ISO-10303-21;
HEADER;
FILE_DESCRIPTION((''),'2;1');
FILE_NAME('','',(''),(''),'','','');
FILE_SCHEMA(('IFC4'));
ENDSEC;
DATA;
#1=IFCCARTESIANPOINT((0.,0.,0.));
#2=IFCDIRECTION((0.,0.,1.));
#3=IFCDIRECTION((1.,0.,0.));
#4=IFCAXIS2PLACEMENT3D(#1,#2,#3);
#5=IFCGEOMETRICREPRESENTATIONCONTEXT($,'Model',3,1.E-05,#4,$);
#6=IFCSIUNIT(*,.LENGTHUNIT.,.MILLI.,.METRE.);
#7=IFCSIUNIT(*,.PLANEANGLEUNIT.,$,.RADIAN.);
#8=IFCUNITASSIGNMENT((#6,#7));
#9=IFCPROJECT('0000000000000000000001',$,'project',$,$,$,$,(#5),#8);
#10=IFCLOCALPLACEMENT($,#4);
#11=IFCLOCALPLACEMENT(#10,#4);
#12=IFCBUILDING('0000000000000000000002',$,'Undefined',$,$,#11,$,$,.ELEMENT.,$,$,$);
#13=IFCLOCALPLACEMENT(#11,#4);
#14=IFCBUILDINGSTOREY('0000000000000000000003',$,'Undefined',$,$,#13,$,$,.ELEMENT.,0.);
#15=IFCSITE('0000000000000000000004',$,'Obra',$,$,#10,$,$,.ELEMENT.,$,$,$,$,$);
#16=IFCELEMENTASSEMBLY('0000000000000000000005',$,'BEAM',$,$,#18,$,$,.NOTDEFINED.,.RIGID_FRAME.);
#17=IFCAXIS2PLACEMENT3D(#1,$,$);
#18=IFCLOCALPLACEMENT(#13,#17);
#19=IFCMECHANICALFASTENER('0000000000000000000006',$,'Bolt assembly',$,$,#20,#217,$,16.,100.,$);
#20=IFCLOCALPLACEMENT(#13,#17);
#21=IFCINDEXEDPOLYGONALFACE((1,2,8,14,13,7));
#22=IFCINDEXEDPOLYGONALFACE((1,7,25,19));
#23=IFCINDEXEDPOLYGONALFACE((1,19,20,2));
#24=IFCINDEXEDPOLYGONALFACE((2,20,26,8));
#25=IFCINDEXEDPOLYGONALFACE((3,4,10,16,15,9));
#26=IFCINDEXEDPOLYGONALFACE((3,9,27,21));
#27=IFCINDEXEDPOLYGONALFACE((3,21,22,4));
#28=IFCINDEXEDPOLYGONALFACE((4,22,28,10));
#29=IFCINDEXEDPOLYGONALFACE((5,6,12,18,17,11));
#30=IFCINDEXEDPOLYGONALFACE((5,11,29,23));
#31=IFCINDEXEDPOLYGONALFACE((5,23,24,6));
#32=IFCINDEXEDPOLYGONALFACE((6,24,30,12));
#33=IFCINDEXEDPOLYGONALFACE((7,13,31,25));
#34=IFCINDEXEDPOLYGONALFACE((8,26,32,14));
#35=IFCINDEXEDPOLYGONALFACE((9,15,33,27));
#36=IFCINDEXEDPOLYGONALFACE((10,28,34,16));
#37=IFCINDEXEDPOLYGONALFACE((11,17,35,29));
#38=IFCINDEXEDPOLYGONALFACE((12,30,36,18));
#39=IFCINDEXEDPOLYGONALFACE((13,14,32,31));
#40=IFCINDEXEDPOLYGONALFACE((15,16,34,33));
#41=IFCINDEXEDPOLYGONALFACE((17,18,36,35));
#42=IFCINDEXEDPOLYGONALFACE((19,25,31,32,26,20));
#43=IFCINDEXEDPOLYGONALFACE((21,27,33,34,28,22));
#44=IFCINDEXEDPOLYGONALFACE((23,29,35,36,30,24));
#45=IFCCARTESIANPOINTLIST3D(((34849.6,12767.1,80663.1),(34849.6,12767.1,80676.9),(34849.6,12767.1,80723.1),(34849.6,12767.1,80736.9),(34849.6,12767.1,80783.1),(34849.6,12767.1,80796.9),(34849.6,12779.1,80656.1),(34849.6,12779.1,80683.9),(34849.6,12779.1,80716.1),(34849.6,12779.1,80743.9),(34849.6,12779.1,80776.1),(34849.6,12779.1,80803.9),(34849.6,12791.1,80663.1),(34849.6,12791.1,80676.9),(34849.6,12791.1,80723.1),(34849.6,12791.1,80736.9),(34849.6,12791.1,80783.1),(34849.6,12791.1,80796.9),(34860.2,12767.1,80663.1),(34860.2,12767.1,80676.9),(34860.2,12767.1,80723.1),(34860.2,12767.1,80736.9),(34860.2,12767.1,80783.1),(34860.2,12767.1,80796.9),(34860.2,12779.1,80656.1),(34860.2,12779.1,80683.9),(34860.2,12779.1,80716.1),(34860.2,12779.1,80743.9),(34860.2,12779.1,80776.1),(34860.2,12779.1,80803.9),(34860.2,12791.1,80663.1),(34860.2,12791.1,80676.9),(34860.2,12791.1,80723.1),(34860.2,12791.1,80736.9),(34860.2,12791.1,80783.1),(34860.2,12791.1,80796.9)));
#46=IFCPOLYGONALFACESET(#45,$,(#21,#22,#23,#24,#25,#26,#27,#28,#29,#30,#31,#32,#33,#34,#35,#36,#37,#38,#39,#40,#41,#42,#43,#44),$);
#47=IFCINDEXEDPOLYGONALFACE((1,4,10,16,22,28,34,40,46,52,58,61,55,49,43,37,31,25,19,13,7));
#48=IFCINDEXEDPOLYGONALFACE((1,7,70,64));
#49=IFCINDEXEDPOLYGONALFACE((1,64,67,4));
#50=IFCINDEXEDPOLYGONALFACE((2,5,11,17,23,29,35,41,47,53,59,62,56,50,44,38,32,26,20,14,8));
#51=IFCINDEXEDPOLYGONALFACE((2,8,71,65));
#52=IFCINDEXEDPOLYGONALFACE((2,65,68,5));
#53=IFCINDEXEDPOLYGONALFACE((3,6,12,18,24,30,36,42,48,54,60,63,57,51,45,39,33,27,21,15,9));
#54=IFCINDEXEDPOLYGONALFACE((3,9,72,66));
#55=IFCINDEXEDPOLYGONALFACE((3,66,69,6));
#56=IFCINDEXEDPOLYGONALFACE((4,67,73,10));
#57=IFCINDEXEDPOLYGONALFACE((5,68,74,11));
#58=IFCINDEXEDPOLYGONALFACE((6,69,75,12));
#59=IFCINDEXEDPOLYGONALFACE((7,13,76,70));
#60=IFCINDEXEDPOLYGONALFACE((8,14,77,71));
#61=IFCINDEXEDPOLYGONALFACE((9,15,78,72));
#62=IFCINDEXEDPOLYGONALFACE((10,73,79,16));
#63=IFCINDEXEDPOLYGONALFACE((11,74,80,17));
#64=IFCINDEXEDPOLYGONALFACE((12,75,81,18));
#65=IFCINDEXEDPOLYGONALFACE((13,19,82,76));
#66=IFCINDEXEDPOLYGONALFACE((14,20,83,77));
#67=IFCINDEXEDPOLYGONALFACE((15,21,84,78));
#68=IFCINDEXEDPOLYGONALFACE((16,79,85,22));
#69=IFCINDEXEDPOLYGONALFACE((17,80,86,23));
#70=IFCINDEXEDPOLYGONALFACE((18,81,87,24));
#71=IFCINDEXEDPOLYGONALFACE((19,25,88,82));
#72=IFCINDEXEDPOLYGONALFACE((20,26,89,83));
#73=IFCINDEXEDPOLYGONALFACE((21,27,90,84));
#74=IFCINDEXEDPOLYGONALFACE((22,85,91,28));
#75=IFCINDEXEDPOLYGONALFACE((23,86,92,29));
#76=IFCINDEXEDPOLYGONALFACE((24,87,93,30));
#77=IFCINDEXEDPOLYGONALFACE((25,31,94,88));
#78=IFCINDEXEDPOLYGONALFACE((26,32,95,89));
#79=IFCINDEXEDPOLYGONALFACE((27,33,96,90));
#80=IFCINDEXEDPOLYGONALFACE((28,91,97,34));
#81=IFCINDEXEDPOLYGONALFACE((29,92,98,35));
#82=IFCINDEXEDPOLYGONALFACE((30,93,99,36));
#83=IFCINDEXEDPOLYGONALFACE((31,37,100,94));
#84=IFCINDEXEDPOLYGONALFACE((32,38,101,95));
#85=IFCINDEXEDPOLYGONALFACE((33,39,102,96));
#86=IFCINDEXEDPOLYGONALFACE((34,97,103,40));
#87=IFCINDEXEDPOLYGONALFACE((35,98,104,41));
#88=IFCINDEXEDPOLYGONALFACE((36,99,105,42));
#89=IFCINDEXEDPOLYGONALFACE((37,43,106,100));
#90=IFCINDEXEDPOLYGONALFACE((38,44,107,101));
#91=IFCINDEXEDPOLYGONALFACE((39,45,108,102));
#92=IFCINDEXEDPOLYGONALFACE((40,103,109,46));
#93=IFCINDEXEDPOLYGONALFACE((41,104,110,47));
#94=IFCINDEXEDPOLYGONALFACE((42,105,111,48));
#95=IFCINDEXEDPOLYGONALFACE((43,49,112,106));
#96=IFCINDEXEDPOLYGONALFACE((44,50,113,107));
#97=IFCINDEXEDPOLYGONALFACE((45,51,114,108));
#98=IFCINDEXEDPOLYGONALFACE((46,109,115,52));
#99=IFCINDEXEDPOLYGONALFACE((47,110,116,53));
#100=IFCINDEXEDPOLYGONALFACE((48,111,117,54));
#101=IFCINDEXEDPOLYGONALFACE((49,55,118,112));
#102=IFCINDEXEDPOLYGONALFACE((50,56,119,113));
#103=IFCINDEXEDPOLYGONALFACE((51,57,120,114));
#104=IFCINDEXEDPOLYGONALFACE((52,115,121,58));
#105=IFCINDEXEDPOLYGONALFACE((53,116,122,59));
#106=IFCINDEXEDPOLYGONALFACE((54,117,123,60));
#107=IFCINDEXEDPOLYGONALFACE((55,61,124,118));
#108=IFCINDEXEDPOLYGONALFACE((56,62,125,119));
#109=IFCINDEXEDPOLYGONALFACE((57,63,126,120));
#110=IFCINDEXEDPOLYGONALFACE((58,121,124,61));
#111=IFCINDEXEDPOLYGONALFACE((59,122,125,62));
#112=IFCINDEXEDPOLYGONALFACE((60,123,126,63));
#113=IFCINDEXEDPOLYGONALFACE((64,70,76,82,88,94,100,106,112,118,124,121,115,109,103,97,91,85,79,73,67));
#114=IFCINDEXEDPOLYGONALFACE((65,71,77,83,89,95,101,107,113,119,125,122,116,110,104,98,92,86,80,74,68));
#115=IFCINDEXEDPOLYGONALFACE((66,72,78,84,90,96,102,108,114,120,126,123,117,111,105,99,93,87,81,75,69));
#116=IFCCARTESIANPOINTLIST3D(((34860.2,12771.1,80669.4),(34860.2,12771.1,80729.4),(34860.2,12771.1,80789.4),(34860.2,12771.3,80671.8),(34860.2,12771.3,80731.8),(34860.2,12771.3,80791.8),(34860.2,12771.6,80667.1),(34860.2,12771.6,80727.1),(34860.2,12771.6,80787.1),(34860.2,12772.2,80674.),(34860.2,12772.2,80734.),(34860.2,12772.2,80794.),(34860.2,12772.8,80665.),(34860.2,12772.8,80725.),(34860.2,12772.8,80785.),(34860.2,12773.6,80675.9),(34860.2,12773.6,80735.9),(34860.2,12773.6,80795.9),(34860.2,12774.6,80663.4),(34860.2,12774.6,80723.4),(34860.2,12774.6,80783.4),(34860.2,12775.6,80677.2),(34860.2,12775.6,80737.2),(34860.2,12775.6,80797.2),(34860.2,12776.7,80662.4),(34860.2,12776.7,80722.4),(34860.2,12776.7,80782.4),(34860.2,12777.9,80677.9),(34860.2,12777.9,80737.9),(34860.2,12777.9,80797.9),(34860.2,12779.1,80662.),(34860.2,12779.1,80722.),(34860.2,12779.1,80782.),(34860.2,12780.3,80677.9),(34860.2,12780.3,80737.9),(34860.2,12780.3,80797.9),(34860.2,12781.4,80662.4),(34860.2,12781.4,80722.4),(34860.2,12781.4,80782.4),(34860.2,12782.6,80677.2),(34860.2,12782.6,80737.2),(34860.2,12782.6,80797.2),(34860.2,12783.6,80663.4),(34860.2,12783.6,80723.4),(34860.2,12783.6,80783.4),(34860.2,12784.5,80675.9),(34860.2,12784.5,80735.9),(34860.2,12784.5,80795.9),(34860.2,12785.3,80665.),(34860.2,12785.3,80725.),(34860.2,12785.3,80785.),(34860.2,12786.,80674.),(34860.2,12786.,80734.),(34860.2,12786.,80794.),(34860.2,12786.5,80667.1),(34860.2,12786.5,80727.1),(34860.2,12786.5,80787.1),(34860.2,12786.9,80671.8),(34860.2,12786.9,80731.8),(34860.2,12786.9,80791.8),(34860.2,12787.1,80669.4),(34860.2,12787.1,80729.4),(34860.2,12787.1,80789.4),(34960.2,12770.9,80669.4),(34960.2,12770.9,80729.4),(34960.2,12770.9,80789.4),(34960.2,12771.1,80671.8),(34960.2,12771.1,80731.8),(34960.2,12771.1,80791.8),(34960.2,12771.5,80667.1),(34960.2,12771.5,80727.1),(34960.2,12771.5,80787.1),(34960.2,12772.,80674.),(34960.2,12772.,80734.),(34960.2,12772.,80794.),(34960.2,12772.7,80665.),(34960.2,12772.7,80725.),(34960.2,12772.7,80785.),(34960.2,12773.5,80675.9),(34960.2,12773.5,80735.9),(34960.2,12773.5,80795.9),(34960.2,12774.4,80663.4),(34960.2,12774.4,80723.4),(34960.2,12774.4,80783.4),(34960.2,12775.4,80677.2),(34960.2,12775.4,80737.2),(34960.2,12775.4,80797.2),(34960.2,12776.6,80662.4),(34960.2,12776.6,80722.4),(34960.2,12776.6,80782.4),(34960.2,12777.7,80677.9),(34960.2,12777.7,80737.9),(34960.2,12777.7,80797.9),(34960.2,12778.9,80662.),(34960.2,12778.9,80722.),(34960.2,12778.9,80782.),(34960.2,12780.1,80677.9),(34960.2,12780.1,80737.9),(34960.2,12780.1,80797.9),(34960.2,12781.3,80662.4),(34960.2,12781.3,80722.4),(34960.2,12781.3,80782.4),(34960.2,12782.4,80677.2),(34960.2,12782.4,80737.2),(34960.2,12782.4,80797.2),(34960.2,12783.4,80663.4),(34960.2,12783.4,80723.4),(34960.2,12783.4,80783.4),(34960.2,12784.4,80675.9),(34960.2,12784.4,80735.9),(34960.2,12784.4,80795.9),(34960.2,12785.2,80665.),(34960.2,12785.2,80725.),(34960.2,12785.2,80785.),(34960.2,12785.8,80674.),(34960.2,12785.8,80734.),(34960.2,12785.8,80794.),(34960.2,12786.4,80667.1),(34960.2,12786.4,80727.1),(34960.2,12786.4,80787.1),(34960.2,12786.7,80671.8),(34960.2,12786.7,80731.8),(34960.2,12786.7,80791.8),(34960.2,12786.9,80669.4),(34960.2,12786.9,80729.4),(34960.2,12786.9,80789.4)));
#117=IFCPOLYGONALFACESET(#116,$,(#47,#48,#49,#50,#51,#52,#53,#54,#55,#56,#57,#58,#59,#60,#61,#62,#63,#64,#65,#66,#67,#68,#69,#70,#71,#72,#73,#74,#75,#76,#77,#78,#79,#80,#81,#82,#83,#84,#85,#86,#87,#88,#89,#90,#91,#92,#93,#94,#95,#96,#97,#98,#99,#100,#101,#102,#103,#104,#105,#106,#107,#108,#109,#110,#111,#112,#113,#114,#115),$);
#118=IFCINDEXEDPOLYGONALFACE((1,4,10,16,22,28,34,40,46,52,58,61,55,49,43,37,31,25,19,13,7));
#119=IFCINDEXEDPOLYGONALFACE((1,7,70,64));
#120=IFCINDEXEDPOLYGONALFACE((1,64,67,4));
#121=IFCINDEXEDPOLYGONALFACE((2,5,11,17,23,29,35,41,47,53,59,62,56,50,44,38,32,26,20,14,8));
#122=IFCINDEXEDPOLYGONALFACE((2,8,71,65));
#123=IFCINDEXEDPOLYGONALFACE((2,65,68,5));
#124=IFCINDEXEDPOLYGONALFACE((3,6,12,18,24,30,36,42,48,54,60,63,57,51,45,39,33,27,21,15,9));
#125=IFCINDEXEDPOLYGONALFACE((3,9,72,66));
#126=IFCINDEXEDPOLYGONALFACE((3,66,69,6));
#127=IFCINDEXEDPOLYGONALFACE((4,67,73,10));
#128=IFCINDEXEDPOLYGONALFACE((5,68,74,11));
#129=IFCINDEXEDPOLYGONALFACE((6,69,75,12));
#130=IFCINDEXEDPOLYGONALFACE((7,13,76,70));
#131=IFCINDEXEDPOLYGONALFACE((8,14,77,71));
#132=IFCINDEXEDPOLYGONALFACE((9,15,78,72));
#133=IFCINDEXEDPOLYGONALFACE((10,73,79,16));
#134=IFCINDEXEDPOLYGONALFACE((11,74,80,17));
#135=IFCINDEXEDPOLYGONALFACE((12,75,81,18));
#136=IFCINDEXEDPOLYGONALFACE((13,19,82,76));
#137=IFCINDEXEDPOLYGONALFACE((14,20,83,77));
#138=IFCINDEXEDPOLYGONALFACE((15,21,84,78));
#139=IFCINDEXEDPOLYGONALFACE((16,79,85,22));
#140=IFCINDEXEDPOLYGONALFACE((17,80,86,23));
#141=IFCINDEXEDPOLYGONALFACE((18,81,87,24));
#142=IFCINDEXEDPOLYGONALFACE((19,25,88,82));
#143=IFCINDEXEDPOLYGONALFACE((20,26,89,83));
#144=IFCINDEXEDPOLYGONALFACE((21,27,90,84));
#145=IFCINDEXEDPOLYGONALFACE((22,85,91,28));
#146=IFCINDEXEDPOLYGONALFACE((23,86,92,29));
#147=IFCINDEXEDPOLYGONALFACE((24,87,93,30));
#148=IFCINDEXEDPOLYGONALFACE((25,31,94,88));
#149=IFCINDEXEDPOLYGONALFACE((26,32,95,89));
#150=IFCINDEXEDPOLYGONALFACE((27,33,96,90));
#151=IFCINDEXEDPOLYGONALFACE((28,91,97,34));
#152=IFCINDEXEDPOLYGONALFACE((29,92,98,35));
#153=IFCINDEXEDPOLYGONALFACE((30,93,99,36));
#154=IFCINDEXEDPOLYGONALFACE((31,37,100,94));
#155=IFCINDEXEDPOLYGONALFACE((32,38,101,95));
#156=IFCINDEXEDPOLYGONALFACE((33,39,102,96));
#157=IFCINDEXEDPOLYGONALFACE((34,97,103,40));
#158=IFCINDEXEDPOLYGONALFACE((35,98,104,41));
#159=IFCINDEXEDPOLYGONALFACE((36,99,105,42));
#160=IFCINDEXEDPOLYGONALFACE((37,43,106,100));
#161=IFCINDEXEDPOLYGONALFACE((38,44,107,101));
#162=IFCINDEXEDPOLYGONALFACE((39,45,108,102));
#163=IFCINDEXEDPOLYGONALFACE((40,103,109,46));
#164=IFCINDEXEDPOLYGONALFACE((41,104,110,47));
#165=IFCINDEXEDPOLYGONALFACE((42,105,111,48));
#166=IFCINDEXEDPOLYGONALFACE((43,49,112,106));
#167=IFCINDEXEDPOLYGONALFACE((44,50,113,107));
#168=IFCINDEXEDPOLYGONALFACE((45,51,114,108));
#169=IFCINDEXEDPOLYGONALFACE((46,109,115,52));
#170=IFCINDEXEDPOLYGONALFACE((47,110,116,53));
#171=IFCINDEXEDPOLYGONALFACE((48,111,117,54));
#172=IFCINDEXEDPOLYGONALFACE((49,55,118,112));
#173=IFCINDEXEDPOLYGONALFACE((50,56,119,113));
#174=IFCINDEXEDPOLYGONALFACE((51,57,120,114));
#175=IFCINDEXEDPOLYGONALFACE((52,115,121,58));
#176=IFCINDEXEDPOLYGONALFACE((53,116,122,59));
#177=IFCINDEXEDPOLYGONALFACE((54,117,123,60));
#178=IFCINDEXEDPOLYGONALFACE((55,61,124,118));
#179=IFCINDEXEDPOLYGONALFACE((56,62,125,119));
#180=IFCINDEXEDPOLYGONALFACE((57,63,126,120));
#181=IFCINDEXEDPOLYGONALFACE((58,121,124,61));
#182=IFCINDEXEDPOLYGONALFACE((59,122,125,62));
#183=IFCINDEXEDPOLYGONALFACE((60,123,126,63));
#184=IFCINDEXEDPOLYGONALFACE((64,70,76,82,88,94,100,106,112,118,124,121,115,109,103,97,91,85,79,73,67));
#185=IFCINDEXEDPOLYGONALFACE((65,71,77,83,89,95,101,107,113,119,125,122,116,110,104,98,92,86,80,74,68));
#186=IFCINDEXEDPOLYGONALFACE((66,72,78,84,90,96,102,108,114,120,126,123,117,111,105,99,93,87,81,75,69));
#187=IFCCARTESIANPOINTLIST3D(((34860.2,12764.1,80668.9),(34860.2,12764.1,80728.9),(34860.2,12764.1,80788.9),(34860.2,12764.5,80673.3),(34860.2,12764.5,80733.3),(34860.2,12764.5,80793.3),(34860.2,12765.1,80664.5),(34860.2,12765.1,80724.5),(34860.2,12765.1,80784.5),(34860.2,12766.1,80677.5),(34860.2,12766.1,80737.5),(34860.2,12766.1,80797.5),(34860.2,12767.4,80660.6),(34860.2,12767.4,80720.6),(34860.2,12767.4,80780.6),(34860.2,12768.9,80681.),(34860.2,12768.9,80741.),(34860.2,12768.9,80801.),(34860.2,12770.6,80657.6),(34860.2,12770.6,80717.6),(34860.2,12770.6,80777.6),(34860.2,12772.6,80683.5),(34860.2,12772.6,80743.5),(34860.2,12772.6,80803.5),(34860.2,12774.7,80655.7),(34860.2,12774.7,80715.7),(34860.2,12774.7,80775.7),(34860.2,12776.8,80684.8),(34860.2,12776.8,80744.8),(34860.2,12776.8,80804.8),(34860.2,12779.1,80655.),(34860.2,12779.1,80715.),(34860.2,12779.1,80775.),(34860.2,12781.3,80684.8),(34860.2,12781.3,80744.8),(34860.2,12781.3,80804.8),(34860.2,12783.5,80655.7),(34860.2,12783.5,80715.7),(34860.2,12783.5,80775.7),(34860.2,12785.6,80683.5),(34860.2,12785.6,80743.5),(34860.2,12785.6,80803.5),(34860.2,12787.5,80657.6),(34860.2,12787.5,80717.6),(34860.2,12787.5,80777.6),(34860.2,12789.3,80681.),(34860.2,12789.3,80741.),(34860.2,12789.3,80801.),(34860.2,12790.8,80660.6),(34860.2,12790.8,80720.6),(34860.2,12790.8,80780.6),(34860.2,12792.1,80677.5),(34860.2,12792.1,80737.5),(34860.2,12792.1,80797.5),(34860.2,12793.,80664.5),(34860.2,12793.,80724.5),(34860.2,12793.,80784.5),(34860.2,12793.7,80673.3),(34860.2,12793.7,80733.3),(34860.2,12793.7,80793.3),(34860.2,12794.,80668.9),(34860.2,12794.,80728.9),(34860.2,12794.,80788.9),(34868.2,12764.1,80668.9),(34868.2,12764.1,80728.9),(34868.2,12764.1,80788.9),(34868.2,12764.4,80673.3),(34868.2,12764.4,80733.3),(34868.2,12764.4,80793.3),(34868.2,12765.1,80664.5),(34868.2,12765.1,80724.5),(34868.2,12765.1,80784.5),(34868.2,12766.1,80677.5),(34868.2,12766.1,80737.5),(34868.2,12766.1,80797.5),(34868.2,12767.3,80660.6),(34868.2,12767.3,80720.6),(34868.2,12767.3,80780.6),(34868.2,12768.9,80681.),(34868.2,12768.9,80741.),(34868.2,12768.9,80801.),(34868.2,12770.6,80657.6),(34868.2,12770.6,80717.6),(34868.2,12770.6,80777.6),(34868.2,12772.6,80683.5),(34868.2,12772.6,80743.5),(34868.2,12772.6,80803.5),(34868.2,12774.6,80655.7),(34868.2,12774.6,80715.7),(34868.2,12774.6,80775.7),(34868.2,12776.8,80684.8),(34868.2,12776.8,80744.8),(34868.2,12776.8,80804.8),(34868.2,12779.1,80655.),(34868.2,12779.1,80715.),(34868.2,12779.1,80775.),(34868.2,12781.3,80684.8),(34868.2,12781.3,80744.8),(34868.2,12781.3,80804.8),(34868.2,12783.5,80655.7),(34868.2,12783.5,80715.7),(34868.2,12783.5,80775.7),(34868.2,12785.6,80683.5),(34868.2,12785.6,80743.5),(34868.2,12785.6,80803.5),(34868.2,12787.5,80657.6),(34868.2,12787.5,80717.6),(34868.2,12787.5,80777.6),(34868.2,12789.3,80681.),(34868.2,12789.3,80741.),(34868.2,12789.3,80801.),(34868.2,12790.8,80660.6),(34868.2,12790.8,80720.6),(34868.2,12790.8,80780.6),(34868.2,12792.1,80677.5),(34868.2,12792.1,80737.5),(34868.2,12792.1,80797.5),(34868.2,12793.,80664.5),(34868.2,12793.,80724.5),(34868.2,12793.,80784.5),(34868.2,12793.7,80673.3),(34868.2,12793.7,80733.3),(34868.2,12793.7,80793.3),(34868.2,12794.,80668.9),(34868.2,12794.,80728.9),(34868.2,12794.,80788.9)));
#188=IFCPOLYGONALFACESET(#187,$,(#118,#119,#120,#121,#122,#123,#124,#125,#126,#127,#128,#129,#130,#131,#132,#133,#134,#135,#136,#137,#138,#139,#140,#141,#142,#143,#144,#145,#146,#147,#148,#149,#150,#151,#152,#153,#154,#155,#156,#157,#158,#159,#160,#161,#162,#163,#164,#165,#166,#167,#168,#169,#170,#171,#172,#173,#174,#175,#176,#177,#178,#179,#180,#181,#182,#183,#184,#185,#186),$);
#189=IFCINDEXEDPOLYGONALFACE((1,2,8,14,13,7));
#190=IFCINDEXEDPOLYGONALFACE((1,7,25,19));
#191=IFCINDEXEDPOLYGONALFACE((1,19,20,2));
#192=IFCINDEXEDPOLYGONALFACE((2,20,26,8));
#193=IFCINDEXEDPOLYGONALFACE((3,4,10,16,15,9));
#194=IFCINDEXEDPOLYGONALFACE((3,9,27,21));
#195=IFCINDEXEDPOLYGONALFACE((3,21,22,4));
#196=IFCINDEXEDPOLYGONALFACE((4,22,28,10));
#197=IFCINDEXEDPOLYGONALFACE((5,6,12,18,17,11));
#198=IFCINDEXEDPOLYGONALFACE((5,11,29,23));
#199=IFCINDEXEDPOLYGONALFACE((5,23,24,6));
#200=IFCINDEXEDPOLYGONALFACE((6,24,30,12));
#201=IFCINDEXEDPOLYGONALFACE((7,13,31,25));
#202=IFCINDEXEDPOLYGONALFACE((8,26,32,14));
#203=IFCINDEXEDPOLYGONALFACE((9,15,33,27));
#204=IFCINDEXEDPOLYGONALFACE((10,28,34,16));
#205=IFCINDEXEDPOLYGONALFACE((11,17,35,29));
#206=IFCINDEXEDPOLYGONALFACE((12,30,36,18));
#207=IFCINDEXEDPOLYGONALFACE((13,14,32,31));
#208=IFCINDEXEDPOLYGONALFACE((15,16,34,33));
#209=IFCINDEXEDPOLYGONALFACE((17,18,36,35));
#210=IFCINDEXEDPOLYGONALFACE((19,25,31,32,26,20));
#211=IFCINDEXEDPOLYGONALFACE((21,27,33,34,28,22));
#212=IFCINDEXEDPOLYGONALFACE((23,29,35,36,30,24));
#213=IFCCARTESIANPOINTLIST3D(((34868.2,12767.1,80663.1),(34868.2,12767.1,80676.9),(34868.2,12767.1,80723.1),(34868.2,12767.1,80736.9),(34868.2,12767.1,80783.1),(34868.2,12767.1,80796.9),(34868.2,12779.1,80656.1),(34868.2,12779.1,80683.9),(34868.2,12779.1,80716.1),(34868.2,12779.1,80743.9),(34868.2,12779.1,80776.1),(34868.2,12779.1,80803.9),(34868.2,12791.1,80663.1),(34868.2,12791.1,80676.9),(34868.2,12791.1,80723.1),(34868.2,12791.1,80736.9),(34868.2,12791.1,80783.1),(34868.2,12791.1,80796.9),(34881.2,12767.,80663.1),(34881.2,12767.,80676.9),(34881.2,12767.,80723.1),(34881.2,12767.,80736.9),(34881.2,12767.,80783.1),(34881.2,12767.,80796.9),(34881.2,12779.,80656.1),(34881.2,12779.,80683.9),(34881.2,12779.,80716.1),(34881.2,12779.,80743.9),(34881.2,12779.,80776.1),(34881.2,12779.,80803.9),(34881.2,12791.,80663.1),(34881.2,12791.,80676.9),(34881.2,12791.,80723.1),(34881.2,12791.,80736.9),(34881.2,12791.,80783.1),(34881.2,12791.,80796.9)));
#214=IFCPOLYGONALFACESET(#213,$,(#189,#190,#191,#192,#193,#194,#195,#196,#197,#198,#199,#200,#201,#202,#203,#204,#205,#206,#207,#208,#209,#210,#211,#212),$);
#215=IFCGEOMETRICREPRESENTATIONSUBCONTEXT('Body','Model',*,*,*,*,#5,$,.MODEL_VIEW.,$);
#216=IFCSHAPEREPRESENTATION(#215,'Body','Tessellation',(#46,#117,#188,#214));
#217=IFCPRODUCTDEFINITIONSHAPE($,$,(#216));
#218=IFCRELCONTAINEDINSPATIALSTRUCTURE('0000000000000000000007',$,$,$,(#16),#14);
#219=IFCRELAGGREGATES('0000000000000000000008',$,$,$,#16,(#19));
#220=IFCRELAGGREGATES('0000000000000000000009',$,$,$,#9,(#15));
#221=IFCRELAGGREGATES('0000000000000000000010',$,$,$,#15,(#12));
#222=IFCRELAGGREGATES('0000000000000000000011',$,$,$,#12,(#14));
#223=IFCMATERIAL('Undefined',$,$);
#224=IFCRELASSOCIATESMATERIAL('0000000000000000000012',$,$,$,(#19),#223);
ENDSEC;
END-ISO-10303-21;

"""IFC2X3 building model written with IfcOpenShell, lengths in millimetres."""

from ifc_helpers import new_model, si_unit, frame, origin_with_axes, origin_2d_with_axis, place, context, subcontext, project, spatial, polyline, circle, outline, extrude, source, transform, mapped, material, element, aggregate, save


model = new_model("IFC2X3")

# Units and contexts
model_context = context("Model", 3, precision=1e-05, world=origin_with_axes())
body_context = subcontext(model_context, "Body", "Model", "MODEL_VIEW")
ifc_project = project(units=[si_unit("LENGTHUNIT", "METRE", prefix="MILLI"), si_unit("PLANEANGLEUNIT", "RADIAN")], contexts=[model_context])

# Site, building, storey
site_placement = place(None, origin_with_axes())
site = spatial("IfcSite", under=ifc_project, at=site_placement, Name="Obra", CompositionType="ELEMENT")
building_placement = place(site_placement, origin_with_axes())
building = spatial("IfcBuilding", under=site, at=building_placement, Name="Undefined", CompositionType="ELEMENT")
storey_placement = place(building_placement, origin_with_axes())
storey = spatial("IfcBuildingStorey", under=building, at=storey_placement, Name="Undefined", CompositionType="ELEMENT", Elevation=0.0)

# Shared definitions
ifc_material_1 = material(Name="Undefined")

# Element assembly, mechanical fastener
assembly_1_placement = place(storey_placement, origin_with_axes())
assembly_1 = element("IfcElementAssembly", 1, at=assembly_1_placement, inside=storey, Name="BEAM", AssemblyPlace="NOTDEFINED", PredefinedType="RIGID_FRAME")
shared_shape_1 = source(origin_with_axes(), body_context, "Body", "SweptSolid", [
    extrude(outline(polyline([(13.9, 0.0), (6.9, 12.0), (-6.9, 12.0), (-13.9, 0.0), (-6.9, -12.0), (6.9, -12.0), (13.9, 0.0)])), frame((0.0, -10.6, 0.0), z_axis=(0.0, 1.0, 0.0), x_axis=(1.0, 0.0, 0.0)), (0.0, 0.0, 1.0), 10.6),
    extrude(circle(Radius=8.0, at=origin_2d_with_axis()), frame((0.0, 0.0, 0.0), z_axis=(0.0, 1.0, 0.0), x_axis=(1.0, 0.0, 0.0)), (0.0, 0.0, 1.0), 100.0),
    extrude(circle(Radius=15.0, at=origin_2d_with_axis()), frame((0.0, 0.0, 0.0), z_axis=(0.0, 1.0, 0.0), x_axis=(1.0, 0.0, 0.0)), (0.0, 0.0, 1.0), 8.0),
    extrude(outline(polyline([(13.9, 0.0), (6.9, 12.0), (-6.9, 12.0), (-13.9, 0.0), (-6.9, -12.0), (6.9, -12.0), (13.9, 0.0)])), frame((0.0, 8.0, 0.0), z_axis=(0.0, 1.0, 0.0), x_axis=(1.0, 0.0, 0.0)), (0.0, 0.0, 1.0), 13.0),
])
mechanical_fastener_1_placement = place(assembly_1_placement, frame((34860.3, 12829.1, 80850.0), z_axis=(-0.001625, -0.999999, 0.0), x_axis=(0.0, 0.0, -1.0)))
mechanical_fastener_1 = element("IfcMechanicalFastener", 2, at=mechanical_fastener_1_placement, material=ifc_material_1, Name="Bolt assembly", NominalDiameter=16.0, NominalLength=100.0, context=body_context, shape_type="MappedRepresentation", body=[
    mapped(shared_shape_1, transform((60.0, 0.0, 50.0))),
    mapped(shared_shape_1, transform((120.0, 0.0, 50.0))),
    mapped(shared_shape_1, transform((180.0, 0.0, 50.0))),
])
aggregate(assembly_1, [mechanical_fastener_1])

save(model, "model.ifc")
